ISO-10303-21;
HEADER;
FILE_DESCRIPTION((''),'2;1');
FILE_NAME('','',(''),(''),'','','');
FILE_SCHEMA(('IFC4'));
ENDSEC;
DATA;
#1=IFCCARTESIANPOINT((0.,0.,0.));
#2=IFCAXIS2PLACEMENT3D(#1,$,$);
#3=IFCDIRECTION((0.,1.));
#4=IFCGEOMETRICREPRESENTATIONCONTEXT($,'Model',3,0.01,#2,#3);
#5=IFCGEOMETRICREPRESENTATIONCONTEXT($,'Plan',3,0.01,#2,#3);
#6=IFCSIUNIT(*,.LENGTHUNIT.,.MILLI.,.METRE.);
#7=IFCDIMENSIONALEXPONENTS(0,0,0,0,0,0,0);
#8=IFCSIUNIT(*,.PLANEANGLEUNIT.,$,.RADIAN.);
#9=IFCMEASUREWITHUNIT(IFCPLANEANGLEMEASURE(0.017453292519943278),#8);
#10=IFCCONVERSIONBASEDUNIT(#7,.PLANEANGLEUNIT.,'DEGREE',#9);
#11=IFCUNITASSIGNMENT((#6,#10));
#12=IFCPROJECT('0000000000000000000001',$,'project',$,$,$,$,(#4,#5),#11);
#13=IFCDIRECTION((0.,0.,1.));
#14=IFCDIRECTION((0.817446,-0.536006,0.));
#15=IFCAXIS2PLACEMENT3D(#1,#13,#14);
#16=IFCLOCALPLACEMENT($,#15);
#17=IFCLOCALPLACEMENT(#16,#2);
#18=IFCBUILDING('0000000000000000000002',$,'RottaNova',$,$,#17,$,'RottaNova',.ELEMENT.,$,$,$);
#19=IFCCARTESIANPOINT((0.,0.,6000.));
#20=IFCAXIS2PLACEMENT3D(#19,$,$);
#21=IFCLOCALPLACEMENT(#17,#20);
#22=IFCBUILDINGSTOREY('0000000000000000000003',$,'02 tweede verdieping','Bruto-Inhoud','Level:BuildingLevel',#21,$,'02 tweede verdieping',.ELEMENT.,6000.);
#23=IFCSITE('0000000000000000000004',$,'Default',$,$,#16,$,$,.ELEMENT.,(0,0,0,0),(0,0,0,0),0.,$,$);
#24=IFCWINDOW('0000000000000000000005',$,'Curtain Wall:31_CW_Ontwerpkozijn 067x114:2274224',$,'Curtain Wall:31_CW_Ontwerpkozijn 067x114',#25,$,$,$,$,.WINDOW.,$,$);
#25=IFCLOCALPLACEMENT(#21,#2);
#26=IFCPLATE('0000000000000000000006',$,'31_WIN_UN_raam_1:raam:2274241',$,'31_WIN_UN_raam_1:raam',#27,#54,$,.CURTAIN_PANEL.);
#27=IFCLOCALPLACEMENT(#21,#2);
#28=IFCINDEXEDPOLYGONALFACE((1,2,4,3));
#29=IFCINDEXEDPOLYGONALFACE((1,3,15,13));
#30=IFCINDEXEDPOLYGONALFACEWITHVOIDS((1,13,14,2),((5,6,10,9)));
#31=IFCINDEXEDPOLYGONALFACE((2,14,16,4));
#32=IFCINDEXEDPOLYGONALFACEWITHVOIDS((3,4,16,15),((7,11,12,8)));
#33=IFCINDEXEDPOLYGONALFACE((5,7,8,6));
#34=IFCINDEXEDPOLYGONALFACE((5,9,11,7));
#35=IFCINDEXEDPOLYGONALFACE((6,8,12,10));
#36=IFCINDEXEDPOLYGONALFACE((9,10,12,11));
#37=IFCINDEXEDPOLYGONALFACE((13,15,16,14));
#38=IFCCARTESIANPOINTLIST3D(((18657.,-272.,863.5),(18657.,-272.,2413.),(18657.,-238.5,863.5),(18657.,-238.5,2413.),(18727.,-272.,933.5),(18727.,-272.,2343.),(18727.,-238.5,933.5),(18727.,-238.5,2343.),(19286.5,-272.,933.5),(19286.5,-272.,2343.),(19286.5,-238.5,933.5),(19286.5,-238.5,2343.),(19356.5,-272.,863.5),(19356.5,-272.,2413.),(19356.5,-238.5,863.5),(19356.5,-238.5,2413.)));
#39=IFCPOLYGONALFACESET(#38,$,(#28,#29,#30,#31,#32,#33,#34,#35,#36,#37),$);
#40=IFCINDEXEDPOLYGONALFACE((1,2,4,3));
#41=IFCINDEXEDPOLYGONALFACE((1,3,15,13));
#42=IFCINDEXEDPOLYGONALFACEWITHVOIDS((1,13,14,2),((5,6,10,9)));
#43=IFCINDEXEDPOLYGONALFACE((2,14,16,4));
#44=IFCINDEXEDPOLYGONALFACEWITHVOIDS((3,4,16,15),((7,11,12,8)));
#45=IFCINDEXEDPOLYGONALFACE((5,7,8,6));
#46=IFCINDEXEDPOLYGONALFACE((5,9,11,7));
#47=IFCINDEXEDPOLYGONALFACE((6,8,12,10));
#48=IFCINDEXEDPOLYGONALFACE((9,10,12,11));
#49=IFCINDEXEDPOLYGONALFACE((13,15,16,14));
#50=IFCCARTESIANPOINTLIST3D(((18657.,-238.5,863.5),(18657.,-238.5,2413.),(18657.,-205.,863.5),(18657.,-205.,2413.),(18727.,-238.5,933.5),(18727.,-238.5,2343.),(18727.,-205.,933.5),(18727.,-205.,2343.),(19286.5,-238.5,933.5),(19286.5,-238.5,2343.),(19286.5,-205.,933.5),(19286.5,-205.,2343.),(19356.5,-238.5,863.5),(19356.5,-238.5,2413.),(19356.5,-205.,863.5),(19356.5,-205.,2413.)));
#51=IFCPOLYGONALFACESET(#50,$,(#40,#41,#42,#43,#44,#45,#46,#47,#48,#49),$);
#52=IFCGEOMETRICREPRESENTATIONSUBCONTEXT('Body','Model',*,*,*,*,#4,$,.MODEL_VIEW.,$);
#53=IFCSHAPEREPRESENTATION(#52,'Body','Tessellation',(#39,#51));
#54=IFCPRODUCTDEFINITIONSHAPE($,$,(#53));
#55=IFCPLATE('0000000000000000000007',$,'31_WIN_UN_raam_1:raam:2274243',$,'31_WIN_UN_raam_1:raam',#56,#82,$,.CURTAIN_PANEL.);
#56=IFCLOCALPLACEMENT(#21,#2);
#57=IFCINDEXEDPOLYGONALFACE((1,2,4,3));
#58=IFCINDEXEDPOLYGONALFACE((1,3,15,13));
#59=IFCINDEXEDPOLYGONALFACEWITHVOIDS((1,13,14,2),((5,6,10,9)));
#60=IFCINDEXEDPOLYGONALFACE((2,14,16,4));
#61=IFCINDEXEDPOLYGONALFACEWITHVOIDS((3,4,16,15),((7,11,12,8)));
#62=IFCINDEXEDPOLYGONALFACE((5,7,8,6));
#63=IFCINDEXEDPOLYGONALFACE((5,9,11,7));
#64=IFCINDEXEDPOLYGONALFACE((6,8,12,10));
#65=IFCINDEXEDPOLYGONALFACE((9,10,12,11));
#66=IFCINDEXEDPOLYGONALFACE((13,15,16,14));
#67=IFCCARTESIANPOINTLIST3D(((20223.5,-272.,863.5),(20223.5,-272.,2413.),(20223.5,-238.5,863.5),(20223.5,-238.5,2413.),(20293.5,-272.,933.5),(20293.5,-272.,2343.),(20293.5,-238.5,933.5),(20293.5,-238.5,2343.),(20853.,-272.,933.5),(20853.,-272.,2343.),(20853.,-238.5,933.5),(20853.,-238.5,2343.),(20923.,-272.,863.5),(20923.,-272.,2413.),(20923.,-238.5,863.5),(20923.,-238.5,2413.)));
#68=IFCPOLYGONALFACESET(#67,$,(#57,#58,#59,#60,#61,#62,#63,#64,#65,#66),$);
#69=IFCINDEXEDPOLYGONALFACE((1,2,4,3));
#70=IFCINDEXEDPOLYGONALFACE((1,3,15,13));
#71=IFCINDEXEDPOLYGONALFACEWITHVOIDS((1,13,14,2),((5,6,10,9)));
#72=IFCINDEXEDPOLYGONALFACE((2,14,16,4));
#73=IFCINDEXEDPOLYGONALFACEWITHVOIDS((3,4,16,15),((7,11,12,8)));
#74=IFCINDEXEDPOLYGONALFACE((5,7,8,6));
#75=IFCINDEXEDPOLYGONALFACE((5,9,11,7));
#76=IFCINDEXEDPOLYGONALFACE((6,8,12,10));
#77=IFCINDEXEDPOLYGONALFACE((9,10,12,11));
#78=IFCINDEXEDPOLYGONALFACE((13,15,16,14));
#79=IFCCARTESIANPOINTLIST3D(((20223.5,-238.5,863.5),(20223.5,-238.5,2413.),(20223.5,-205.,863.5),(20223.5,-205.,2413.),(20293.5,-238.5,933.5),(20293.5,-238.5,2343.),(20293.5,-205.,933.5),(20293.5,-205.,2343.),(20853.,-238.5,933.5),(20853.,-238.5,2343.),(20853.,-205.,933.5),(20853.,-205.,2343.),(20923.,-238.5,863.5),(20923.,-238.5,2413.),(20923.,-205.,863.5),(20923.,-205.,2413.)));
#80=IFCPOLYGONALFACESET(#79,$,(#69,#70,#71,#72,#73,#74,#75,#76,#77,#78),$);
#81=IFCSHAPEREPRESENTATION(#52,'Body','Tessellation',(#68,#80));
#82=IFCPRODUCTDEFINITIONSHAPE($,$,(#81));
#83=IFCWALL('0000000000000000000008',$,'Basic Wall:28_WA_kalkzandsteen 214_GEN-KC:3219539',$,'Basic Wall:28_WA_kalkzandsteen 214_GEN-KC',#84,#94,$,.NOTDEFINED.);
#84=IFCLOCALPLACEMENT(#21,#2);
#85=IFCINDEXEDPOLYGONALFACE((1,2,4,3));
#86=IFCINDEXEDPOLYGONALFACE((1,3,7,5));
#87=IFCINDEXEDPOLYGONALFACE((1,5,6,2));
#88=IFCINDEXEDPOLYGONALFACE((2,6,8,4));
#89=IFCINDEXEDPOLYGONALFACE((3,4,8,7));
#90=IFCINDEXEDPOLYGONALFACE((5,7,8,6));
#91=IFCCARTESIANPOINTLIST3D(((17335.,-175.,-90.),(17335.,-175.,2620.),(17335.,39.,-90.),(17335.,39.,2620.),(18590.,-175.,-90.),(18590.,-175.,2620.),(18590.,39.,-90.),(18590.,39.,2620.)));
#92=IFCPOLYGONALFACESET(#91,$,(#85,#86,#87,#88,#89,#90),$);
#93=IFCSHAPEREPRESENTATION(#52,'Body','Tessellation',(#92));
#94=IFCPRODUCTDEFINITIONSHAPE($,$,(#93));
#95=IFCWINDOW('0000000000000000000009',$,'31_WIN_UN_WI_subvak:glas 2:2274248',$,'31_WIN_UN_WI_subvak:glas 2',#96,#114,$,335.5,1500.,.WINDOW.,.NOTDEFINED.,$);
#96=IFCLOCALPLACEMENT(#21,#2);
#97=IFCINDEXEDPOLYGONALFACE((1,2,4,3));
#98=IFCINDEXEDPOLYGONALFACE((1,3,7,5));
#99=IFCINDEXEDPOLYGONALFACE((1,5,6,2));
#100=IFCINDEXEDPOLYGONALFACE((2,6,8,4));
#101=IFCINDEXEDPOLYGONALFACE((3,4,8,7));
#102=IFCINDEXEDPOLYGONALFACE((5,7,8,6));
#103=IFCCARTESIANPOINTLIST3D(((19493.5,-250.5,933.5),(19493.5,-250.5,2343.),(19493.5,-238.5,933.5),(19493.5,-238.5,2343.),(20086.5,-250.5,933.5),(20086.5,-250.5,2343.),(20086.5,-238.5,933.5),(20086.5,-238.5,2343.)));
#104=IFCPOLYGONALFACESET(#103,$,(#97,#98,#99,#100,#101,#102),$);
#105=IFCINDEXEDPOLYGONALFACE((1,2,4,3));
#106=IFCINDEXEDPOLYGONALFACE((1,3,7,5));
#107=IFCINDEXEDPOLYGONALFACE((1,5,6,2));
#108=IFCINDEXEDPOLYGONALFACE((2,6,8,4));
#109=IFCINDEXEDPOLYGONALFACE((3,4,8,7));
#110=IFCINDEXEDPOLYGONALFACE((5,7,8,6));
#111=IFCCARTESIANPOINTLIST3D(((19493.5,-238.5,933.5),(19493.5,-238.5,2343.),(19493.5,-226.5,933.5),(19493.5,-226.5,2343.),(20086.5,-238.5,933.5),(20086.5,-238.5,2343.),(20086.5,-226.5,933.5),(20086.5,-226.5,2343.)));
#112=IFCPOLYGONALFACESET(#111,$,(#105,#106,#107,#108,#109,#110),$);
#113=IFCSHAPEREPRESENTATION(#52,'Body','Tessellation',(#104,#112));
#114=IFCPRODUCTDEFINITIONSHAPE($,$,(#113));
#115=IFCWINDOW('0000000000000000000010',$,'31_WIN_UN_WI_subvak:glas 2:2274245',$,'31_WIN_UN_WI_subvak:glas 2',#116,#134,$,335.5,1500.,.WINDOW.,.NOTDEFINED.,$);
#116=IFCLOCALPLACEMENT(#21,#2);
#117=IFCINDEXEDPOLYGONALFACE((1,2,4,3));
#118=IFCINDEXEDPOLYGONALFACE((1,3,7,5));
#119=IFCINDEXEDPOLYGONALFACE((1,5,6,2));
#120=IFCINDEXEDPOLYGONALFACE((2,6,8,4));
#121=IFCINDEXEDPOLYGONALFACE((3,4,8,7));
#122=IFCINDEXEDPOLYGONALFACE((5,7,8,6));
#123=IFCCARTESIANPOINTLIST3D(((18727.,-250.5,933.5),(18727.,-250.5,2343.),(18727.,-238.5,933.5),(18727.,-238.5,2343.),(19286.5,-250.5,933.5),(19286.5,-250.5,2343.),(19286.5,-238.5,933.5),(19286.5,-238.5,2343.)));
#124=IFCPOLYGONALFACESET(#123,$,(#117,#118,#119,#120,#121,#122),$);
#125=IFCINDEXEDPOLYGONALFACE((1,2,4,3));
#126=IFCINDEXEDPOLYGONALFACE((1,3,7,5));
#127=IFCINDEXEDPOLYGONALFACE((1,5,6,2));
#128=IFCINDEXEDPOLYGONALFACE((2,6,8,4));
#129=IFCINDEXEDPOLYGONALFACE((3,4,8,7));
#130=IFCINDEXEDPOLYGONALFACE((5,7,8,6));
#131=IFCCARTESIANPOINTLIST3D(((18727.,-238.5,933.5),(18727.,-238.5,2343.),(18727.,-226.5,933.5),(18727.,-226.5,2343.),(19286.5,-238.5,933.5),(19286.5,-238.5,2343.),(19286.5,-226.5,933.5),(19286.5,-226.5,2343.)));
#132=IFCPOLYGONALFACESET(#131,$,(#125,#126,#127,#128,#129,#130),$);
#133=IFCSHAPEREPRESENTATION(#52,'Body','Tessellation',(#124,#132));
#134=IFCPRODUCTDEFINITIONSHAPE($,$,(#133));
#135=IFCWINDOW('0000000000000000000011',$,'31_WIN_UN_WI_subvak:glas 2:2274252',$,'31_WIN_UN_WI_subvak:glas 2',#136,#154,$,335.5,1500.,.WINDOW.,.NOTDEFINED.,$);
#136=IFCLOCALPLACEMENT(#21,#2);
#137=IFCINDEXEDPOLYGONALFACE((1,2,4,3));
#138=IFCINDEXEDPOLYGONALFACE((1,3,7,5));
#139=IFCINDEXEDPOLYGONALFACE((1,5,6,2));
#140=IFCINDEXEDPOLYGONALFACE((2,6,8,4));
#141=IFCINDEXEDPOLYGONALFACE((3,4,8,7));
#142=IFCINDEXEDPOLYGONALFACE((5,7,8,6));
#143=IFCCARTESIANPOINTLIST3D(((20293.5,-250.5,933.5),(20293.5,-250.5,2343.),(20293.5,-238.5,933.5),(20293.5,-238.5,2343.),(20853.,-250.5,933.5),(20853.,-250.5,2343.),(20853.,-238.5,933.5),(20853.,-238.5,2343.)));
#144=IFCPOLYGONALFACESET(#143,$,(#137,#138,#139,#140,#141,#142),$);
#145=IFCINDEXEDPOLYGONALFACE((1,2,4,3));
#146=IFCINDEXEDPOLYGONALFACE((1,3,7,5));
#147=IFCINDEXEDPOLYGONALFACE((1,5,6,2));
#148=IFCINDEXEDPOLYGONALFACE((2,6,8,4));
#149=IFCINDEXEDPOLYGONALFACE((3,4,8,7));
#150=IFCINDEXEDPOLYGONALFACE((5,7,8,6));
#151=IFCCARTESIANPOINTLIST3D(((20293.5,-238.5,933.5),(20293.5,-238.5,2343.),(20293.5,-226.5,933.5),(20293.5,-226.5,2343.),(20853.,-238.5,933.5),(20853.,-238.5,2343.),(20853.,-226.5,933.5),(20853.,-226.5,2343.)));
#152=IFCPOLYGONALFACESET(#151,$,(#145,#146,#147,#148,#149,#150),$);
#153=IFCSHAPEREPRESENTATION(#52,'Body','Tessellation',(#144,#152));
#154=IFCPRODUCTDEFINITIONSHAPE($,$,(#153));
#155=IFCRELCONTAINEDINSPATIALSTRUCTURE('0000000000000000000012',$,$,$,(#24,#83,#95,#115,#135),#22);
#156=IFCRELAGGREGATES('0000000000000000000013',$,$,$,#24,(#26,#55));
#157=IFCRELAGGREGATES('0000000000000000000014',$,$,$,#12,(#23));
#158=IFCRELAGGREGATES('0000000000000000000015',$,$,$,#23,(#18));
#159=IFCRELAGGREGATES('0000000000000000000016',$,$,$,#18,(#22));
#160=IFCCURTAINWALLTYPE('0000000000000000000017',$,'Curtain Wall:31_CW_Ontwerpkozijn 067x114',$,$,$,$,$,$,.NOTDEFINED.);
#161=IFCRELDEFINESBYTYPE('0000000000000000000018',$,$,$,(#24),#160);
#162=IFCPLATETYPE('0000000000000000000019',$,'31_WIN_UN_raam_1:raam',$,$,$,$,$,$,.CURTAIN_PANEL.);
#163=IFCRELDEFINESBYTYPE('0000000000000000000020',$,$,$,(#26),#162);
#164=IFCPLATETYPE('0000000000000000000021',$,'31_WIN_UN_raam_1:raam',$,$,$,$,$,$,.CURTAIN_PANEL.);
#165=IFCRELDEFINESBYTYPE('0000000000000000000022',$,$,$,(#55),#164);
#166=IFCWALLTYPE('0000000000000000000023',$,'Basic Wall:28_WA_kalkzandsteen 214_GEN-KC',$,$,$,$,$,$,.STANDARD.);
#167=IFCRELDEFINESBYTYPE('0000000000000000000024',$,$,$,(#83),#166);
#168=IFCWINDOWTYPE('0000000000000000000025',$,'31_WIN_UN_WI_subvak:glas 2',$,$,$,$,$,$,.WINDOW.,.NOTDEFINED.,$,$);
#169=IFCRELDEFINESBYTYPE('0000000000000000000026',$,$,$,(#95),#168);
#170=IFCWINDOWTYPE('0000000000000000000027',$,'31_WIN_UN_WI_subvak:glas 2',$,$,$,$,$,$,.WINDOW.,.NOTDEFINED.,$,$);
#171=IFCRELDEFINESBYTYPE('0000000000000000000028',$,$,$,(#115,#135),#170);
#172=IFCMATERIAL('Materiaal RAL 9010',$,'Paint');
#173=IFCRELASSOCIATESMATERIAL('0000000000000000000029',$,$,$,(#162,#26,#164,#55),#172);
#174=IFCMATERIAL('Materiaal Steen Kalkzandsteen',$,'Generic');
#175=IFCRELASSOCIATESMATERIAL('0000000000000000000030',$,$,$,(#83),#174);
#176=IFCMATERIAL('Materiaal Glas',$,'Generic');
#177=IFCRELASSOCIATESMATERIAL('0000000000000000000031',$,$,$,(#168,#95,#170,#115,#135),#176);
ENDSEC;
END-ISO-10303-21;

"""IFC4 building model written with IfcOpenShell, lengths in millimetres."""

from ifc_helpers import new_model, entity, si_unit, converted_unit, direction, frame, origin, place, context, subcontext, project, spatial, indexed_curve, outline, extrude, source, transform, mapped, material, type_object, type_shapes, element, aggregate, save


model = new_model("IFC4")

# Units and contexts
model_context = context("Model", 3, precision=0.01, world=origin(), true_north=direction((0.0, 1.0)))
plan_context = context("Plan", 3, precision=0.01, world=origin(), true_north=direction((0.0, 1.0)))
body_context = subcontext(model_context, "Body", "Model", "MODEL_VIEW")
ifc_project = project(units=[si_unit("LENGTHUNIT", "METRE", prefix="MILLI"), converted_unit("PLANEANGLEUNIT", "DEGREE", entity("IfcPlaneAngleMeasure", 0.017453292519943278), si_unit("PLANEANGLEUNIT", "RADIAN"), dimensions=[0, 0, 0, 0, 0, 0, 0])], contexts=[model_context, plan_context])

# Site, building, storey
site_placement = place(None, frame((0.0, 0.0, 0.0), z_axis=(0.0, 0.0, 1.0), x_axis=(0.817446, -0.536006, 0.0)))
site = spatial("IfcSite", under=ifc_project, at=site_placement, Name="Default", CompositionType="ELEMENT", RefLatitude=(0, 0, 0, 0), RefLongitude=(0, 0, 0, 0), RefElevation=0.0)
building_placement = place(site_placement, origin())
building = spatial("IfcBuilding", under=site, at=building_placement, Name="RottaNova", LongName="RottaNova", CompositionType="ELEMENT")
storey_placement = place(building_placement, frame((0.0, 0.0, 6000.0)))
storey = spatial("IfcBuildingStorey", under=building, at=storey_placement, Name="02 tweede verdieping", Description="Bruto-Inhoud", ObjectType="Level:BuildingLevel", LongName="02 tweede verdieping", CompositionType="ELEMENT", Elevation=6000.0)

# Shared definitions
curtain_wall_type = type_object("IfcCurtainWallType", Name="Curtain Wall:31_CW_Ontwerpkozijn 067x114", PredefinedType="NOTDEFINED")

# Window
window_1_placement = place(storey_placement, frame((0.0, 0.0, -6000.0)))
window_1 = element("IfcWindow", 1, at=window_1_placement, inside=storey, type_object=curtain_wall_type, Name="Curtain Wall:31_CW_Ontwerpkozijn 067x114:2274224", ObjectType="Curtain Wall:31_CW_Ontwerpkozijn 067x114", PredefinedType="WINDOW")

# Plates
ifc_material_1 = material(Name="Materiaal Glas", Category="Generic")
ifc_material_2 = material(Name="Materiaal RAL 9010", Category="Paint")
plate_type_1 = type_object("IfcPlateType", Name="31_WIN_UN_raam_1:raam", PredefinedType="CURTAIN_PANEL", material=ifc_material_2)
shared_shape_1 = source(origin(), body_context, "Body", "SweptSolid", [
    extrude(outline(indexed_curve([(-349.7, -774.8), (349.7, -774.8), (349.7, 774.8), (-349.7, 774.8), (-349.7, -774.8)], self_intersect=False), holes=[indexed_curve([(-279.7, 704.8), (279.7, 704.8), (279.7, -704.8), (-279.7, -704.8), (-279.7, 704.8)], self_intersect=False)]), frame((0.0, -92.0, 774.8), z_axis=(0.0, 1.0, 0.0), x_axis=(1.0, 0.0, 0.0)), (0.0, 0.0, 1.0), 33.5),
    extrude(outline(indexed_curve([(-349.7, -774.8), (349.7, -774.8), (349.7, 774.8), (-349.7, 774.8), (-349.7, -774.8)], self_intersect=False), holes=[indexed_curve([(-279.7, 704.7), (279.7, 704.7), (279.7, -704.8), (-279.7, -704.8), (-279.7, 704.7)], self_intersect=False)]), frame((0.0, -58.5, 774.8), z_axis=(0.0, 1.0, 0.0), x_axis=(1.0, 0.0, 0.0)), (0.0, 0.0, 1.0), 33.5),
])
type_shapes(plate_type_1, [shared_shape_1])
plate_1_placement = place(window_1_placement, frame((19006.8, -180.0, 6863.5)))
plate_1 = element("IfcPlate", 2, at=plate_1_placement, type_object=plate_type_1, material=ifc_material_2, Name="31_WIN_UN_raam_1:raam:2274241", ObjectType="31_WIN_UN_raam_1:raam", PredefinedType="CURTAIN_PANEL", context=body_context, shape_type="MappedRepresentation", body=[
    mapped(shared_shape_1, transform((0.0, 0.0, 0.0), scale=1.0)),
])
plate_type_2 = type_object("IfcPlateType", Name="31_WIN_UN_raam_1:raam", PredefinedType="CURTAIN_PANEL", material=ifc_material_2)
shared_shape_2 = source(origin(), body_context, "Body", "SweptSolid", [
    extrude(outline(indexed_curve([(-349.7, -774.8), (349.7, -774.8), (349.7, 774.8), (-349.7, 774.8), (-349.7, -774.8)], self_intersect=False), holes=[indexed_curve([(-279.7, 704.8), (279.7, 704.8), (279.7, -704.8), (-279.7, -704.8), (-279.7, 704.8)], self_intersect=False)]), frame((0.0, -92.0, 774.8), z_axis=(0.0, 1.0, 0.0), x_axis=(1.0, 0.0, 0.0)), (0.0, 0.0, 1.0), 33.5),
    extrude(outline(indexed_curve([(-349.7, -774.8), (349.7, -774.8), (349.7, 774.8), (-349.7, 774.8), (-349.7, -774.8)], self_intersect=False), holes=[indexed_curve([(-279.7, 704.7), (279.7, 704.7), (279.7, -704.8), (-279.7, -704.8), (-279.7, 704.7)], self_intersect=False)]), frame((0.0, -58.5, 774.8), z_axis=(0.0, 1.0, 0.0), x_axis=(1.0, 0.0, 0.0)), (0.0, 0.0, 1.0), 33.5),
])
type_shapes(plate_type_2, [shared_shape_2])
plate_2_placement = place(window_1_placement, frame((20573.3, -180.0, 6863.5)))
plate_2 = element("IfcPlate", 3, at=plate_2_placement, type_object=plate_type_2, material=ifc_material_2, Name="31_WIN_UN_raam_1:raam:2274243", ObjectType="31_WIN_UN_raam_1:raam", PredefinedType="CURTAIN_PANEL", context=body_context, shape_type="MappedRepresentation", body=[
    mapped(shared_shape_2, transform((0.0, 0.0, 0.0), scale=1.0)),
])
aggregate(window_1, [plate_1, plate_2])

# Wall
ifc_material_3 = material(Name="Materiaal Steen Kalkzandsteen", Category="Generic")
wall_type = type_object("IfcWallType", Name="Basic Wall:28_WA_kalkzandsteen 214_GEN-KC", PredefinedType="STANDARD")
wall_placement = place(storey_placement, frame((18590.0, -68.0, -90.0), z_axis=(0.0, 0.0, 1.0), x_axis=(-1.0, 0.0, 0.0)))
element("IfcWall", 4, at=wall_placement, inside=storey, type_object=wall_type, material=ifc_material_3, Name="Basic Wall:28_WA_kalkzandsteen 214_GEN-KC:3219539", ObjectType="Basic Wall:28_WA_kalkzandsteen 214_GEN-KC", PredefinedType="NOTDEFINED", context=body_context, shape_type="SweptSolid", body=[
    extrude(outline(indexed_curve([(1255.0, 107.0), (0.0, 107.0), (0.0, -107.0), (1255.0, -107.0), (1255.0, 107.0)], self_intersect=False)), origin(), (0.0, 0.0, 1.0), 2710.0),
])

# Windows
window_type_1 = type_object("IfcWindowType", Name="31_WIN_UN_WI_subvak:glas 2", PartitioningType="NOTDEFINED", PredefinedType="WINDOW", material=ifc_material_1)
shared_shape_3 = source(origin(), body_context, "Body", "SweptSolid", [
    extrude(outline(indexed_curve([(-296.5, -6.0), (296.5, -6.0), (296.5, 6.0), (-296.5, 6.0), (-296.5, -6.0)], self_intersect=False)), frame((0.0, -6.0, 0.0)), (0.0, 0.0, 1.0), 1409.5),
    extrude(outline(indexed_curve([(-296.5, -6.0), (296.5, -6.0), (296.5, 6.0), (-296.5, 6.0), (-296.5, -6.0)], self_intersect=False)), frame((0.0, 6.0, 0.0)), (0.0, 0.0, 1.0), 1409.5),
])
type_shapes(window_type_1, [shared_shape_3])
window_2_placement = place(storey_placement, frame((19790.0, -238.5, 933.5)))
element("IfcWindow", 5, at=window_2_placement, inside=storey, type_object=window_type_1, material=ifc_material_1, Name="31_WIN_UN_WI_subvak:glas 2:2274248", ObjectType="31_WIN_UN_WI_subvak:glas 2", OverallHeight=335.5, OverallWidth=1500.0, PartitioningType="NOTDEFINED", PredefinedType="WINDOW", context=body_context, shape_type="MappedRepresentation", body=[
    mapped(shared_shape_3, transform((0.0, 0.0, 0.0), scale=1.0)),
])
window_type_2 = type_object("IfcWindowType", Name="31_WIN_UN_WI_subvak:glas 2", PartitioningType="NOTDEFINED", PredefinedType="WINDOW", material=ifc_material_1)
shared_shape_4 = source(origin(), body_context, "Body", "SweptSolid", [
    extrude(outline(indexed_curve([(-279.8, -6.0), (279.8, -6.0), (279.8, 6.0), (-279.8, 6.0), (-279.8, -6.0)], self_intersect=False)), frame((0.0, -6.0, 0.0)), (0.0, 0.0, 1.0), 1409.5),
    extrude(outline(indexed_curve([(-279.8, -6.0), (279.8, -6.0), (279.8, 6.0), (-279.8, 6.0), (-279.8, -6.0)], self_intersect=False)), frame((0.0, 6.0, 0.0)), (0.0, 0.0, 1.0), 1409.5),
])
type_shapes(window_type_2, [shared_shape_4])
for number, where, name in (
    (6, (19006.8, -238.5, 933.5), "31_WIN_UN_WI_subvak:glas 2:2274245"),
    (7, (20573.3, -238.5, 933.5), "31_WIN_UN_WI_subvak:glas 2:2274252"),
):
    element("IfcWindow", number, at=place(storey_placement, frame(where)), inside=storey, type_object=window_type_2, material=ifc_material_1, Name=name, ObjectType="31_WIN_UN_WI_subvak:glas 2", OverallHeight=335.5, OverallWidth=1500.0, PartitioningType="NOTDEFINED", PredefinedType="WINDOW", context=body_context, shape_type="MappedRepresentation", body=[
        mapped(shared_shape_4, transform((0.0, 0.0, 0.0), scale=1.0)),
    ])

save(model, "model.ifc")
